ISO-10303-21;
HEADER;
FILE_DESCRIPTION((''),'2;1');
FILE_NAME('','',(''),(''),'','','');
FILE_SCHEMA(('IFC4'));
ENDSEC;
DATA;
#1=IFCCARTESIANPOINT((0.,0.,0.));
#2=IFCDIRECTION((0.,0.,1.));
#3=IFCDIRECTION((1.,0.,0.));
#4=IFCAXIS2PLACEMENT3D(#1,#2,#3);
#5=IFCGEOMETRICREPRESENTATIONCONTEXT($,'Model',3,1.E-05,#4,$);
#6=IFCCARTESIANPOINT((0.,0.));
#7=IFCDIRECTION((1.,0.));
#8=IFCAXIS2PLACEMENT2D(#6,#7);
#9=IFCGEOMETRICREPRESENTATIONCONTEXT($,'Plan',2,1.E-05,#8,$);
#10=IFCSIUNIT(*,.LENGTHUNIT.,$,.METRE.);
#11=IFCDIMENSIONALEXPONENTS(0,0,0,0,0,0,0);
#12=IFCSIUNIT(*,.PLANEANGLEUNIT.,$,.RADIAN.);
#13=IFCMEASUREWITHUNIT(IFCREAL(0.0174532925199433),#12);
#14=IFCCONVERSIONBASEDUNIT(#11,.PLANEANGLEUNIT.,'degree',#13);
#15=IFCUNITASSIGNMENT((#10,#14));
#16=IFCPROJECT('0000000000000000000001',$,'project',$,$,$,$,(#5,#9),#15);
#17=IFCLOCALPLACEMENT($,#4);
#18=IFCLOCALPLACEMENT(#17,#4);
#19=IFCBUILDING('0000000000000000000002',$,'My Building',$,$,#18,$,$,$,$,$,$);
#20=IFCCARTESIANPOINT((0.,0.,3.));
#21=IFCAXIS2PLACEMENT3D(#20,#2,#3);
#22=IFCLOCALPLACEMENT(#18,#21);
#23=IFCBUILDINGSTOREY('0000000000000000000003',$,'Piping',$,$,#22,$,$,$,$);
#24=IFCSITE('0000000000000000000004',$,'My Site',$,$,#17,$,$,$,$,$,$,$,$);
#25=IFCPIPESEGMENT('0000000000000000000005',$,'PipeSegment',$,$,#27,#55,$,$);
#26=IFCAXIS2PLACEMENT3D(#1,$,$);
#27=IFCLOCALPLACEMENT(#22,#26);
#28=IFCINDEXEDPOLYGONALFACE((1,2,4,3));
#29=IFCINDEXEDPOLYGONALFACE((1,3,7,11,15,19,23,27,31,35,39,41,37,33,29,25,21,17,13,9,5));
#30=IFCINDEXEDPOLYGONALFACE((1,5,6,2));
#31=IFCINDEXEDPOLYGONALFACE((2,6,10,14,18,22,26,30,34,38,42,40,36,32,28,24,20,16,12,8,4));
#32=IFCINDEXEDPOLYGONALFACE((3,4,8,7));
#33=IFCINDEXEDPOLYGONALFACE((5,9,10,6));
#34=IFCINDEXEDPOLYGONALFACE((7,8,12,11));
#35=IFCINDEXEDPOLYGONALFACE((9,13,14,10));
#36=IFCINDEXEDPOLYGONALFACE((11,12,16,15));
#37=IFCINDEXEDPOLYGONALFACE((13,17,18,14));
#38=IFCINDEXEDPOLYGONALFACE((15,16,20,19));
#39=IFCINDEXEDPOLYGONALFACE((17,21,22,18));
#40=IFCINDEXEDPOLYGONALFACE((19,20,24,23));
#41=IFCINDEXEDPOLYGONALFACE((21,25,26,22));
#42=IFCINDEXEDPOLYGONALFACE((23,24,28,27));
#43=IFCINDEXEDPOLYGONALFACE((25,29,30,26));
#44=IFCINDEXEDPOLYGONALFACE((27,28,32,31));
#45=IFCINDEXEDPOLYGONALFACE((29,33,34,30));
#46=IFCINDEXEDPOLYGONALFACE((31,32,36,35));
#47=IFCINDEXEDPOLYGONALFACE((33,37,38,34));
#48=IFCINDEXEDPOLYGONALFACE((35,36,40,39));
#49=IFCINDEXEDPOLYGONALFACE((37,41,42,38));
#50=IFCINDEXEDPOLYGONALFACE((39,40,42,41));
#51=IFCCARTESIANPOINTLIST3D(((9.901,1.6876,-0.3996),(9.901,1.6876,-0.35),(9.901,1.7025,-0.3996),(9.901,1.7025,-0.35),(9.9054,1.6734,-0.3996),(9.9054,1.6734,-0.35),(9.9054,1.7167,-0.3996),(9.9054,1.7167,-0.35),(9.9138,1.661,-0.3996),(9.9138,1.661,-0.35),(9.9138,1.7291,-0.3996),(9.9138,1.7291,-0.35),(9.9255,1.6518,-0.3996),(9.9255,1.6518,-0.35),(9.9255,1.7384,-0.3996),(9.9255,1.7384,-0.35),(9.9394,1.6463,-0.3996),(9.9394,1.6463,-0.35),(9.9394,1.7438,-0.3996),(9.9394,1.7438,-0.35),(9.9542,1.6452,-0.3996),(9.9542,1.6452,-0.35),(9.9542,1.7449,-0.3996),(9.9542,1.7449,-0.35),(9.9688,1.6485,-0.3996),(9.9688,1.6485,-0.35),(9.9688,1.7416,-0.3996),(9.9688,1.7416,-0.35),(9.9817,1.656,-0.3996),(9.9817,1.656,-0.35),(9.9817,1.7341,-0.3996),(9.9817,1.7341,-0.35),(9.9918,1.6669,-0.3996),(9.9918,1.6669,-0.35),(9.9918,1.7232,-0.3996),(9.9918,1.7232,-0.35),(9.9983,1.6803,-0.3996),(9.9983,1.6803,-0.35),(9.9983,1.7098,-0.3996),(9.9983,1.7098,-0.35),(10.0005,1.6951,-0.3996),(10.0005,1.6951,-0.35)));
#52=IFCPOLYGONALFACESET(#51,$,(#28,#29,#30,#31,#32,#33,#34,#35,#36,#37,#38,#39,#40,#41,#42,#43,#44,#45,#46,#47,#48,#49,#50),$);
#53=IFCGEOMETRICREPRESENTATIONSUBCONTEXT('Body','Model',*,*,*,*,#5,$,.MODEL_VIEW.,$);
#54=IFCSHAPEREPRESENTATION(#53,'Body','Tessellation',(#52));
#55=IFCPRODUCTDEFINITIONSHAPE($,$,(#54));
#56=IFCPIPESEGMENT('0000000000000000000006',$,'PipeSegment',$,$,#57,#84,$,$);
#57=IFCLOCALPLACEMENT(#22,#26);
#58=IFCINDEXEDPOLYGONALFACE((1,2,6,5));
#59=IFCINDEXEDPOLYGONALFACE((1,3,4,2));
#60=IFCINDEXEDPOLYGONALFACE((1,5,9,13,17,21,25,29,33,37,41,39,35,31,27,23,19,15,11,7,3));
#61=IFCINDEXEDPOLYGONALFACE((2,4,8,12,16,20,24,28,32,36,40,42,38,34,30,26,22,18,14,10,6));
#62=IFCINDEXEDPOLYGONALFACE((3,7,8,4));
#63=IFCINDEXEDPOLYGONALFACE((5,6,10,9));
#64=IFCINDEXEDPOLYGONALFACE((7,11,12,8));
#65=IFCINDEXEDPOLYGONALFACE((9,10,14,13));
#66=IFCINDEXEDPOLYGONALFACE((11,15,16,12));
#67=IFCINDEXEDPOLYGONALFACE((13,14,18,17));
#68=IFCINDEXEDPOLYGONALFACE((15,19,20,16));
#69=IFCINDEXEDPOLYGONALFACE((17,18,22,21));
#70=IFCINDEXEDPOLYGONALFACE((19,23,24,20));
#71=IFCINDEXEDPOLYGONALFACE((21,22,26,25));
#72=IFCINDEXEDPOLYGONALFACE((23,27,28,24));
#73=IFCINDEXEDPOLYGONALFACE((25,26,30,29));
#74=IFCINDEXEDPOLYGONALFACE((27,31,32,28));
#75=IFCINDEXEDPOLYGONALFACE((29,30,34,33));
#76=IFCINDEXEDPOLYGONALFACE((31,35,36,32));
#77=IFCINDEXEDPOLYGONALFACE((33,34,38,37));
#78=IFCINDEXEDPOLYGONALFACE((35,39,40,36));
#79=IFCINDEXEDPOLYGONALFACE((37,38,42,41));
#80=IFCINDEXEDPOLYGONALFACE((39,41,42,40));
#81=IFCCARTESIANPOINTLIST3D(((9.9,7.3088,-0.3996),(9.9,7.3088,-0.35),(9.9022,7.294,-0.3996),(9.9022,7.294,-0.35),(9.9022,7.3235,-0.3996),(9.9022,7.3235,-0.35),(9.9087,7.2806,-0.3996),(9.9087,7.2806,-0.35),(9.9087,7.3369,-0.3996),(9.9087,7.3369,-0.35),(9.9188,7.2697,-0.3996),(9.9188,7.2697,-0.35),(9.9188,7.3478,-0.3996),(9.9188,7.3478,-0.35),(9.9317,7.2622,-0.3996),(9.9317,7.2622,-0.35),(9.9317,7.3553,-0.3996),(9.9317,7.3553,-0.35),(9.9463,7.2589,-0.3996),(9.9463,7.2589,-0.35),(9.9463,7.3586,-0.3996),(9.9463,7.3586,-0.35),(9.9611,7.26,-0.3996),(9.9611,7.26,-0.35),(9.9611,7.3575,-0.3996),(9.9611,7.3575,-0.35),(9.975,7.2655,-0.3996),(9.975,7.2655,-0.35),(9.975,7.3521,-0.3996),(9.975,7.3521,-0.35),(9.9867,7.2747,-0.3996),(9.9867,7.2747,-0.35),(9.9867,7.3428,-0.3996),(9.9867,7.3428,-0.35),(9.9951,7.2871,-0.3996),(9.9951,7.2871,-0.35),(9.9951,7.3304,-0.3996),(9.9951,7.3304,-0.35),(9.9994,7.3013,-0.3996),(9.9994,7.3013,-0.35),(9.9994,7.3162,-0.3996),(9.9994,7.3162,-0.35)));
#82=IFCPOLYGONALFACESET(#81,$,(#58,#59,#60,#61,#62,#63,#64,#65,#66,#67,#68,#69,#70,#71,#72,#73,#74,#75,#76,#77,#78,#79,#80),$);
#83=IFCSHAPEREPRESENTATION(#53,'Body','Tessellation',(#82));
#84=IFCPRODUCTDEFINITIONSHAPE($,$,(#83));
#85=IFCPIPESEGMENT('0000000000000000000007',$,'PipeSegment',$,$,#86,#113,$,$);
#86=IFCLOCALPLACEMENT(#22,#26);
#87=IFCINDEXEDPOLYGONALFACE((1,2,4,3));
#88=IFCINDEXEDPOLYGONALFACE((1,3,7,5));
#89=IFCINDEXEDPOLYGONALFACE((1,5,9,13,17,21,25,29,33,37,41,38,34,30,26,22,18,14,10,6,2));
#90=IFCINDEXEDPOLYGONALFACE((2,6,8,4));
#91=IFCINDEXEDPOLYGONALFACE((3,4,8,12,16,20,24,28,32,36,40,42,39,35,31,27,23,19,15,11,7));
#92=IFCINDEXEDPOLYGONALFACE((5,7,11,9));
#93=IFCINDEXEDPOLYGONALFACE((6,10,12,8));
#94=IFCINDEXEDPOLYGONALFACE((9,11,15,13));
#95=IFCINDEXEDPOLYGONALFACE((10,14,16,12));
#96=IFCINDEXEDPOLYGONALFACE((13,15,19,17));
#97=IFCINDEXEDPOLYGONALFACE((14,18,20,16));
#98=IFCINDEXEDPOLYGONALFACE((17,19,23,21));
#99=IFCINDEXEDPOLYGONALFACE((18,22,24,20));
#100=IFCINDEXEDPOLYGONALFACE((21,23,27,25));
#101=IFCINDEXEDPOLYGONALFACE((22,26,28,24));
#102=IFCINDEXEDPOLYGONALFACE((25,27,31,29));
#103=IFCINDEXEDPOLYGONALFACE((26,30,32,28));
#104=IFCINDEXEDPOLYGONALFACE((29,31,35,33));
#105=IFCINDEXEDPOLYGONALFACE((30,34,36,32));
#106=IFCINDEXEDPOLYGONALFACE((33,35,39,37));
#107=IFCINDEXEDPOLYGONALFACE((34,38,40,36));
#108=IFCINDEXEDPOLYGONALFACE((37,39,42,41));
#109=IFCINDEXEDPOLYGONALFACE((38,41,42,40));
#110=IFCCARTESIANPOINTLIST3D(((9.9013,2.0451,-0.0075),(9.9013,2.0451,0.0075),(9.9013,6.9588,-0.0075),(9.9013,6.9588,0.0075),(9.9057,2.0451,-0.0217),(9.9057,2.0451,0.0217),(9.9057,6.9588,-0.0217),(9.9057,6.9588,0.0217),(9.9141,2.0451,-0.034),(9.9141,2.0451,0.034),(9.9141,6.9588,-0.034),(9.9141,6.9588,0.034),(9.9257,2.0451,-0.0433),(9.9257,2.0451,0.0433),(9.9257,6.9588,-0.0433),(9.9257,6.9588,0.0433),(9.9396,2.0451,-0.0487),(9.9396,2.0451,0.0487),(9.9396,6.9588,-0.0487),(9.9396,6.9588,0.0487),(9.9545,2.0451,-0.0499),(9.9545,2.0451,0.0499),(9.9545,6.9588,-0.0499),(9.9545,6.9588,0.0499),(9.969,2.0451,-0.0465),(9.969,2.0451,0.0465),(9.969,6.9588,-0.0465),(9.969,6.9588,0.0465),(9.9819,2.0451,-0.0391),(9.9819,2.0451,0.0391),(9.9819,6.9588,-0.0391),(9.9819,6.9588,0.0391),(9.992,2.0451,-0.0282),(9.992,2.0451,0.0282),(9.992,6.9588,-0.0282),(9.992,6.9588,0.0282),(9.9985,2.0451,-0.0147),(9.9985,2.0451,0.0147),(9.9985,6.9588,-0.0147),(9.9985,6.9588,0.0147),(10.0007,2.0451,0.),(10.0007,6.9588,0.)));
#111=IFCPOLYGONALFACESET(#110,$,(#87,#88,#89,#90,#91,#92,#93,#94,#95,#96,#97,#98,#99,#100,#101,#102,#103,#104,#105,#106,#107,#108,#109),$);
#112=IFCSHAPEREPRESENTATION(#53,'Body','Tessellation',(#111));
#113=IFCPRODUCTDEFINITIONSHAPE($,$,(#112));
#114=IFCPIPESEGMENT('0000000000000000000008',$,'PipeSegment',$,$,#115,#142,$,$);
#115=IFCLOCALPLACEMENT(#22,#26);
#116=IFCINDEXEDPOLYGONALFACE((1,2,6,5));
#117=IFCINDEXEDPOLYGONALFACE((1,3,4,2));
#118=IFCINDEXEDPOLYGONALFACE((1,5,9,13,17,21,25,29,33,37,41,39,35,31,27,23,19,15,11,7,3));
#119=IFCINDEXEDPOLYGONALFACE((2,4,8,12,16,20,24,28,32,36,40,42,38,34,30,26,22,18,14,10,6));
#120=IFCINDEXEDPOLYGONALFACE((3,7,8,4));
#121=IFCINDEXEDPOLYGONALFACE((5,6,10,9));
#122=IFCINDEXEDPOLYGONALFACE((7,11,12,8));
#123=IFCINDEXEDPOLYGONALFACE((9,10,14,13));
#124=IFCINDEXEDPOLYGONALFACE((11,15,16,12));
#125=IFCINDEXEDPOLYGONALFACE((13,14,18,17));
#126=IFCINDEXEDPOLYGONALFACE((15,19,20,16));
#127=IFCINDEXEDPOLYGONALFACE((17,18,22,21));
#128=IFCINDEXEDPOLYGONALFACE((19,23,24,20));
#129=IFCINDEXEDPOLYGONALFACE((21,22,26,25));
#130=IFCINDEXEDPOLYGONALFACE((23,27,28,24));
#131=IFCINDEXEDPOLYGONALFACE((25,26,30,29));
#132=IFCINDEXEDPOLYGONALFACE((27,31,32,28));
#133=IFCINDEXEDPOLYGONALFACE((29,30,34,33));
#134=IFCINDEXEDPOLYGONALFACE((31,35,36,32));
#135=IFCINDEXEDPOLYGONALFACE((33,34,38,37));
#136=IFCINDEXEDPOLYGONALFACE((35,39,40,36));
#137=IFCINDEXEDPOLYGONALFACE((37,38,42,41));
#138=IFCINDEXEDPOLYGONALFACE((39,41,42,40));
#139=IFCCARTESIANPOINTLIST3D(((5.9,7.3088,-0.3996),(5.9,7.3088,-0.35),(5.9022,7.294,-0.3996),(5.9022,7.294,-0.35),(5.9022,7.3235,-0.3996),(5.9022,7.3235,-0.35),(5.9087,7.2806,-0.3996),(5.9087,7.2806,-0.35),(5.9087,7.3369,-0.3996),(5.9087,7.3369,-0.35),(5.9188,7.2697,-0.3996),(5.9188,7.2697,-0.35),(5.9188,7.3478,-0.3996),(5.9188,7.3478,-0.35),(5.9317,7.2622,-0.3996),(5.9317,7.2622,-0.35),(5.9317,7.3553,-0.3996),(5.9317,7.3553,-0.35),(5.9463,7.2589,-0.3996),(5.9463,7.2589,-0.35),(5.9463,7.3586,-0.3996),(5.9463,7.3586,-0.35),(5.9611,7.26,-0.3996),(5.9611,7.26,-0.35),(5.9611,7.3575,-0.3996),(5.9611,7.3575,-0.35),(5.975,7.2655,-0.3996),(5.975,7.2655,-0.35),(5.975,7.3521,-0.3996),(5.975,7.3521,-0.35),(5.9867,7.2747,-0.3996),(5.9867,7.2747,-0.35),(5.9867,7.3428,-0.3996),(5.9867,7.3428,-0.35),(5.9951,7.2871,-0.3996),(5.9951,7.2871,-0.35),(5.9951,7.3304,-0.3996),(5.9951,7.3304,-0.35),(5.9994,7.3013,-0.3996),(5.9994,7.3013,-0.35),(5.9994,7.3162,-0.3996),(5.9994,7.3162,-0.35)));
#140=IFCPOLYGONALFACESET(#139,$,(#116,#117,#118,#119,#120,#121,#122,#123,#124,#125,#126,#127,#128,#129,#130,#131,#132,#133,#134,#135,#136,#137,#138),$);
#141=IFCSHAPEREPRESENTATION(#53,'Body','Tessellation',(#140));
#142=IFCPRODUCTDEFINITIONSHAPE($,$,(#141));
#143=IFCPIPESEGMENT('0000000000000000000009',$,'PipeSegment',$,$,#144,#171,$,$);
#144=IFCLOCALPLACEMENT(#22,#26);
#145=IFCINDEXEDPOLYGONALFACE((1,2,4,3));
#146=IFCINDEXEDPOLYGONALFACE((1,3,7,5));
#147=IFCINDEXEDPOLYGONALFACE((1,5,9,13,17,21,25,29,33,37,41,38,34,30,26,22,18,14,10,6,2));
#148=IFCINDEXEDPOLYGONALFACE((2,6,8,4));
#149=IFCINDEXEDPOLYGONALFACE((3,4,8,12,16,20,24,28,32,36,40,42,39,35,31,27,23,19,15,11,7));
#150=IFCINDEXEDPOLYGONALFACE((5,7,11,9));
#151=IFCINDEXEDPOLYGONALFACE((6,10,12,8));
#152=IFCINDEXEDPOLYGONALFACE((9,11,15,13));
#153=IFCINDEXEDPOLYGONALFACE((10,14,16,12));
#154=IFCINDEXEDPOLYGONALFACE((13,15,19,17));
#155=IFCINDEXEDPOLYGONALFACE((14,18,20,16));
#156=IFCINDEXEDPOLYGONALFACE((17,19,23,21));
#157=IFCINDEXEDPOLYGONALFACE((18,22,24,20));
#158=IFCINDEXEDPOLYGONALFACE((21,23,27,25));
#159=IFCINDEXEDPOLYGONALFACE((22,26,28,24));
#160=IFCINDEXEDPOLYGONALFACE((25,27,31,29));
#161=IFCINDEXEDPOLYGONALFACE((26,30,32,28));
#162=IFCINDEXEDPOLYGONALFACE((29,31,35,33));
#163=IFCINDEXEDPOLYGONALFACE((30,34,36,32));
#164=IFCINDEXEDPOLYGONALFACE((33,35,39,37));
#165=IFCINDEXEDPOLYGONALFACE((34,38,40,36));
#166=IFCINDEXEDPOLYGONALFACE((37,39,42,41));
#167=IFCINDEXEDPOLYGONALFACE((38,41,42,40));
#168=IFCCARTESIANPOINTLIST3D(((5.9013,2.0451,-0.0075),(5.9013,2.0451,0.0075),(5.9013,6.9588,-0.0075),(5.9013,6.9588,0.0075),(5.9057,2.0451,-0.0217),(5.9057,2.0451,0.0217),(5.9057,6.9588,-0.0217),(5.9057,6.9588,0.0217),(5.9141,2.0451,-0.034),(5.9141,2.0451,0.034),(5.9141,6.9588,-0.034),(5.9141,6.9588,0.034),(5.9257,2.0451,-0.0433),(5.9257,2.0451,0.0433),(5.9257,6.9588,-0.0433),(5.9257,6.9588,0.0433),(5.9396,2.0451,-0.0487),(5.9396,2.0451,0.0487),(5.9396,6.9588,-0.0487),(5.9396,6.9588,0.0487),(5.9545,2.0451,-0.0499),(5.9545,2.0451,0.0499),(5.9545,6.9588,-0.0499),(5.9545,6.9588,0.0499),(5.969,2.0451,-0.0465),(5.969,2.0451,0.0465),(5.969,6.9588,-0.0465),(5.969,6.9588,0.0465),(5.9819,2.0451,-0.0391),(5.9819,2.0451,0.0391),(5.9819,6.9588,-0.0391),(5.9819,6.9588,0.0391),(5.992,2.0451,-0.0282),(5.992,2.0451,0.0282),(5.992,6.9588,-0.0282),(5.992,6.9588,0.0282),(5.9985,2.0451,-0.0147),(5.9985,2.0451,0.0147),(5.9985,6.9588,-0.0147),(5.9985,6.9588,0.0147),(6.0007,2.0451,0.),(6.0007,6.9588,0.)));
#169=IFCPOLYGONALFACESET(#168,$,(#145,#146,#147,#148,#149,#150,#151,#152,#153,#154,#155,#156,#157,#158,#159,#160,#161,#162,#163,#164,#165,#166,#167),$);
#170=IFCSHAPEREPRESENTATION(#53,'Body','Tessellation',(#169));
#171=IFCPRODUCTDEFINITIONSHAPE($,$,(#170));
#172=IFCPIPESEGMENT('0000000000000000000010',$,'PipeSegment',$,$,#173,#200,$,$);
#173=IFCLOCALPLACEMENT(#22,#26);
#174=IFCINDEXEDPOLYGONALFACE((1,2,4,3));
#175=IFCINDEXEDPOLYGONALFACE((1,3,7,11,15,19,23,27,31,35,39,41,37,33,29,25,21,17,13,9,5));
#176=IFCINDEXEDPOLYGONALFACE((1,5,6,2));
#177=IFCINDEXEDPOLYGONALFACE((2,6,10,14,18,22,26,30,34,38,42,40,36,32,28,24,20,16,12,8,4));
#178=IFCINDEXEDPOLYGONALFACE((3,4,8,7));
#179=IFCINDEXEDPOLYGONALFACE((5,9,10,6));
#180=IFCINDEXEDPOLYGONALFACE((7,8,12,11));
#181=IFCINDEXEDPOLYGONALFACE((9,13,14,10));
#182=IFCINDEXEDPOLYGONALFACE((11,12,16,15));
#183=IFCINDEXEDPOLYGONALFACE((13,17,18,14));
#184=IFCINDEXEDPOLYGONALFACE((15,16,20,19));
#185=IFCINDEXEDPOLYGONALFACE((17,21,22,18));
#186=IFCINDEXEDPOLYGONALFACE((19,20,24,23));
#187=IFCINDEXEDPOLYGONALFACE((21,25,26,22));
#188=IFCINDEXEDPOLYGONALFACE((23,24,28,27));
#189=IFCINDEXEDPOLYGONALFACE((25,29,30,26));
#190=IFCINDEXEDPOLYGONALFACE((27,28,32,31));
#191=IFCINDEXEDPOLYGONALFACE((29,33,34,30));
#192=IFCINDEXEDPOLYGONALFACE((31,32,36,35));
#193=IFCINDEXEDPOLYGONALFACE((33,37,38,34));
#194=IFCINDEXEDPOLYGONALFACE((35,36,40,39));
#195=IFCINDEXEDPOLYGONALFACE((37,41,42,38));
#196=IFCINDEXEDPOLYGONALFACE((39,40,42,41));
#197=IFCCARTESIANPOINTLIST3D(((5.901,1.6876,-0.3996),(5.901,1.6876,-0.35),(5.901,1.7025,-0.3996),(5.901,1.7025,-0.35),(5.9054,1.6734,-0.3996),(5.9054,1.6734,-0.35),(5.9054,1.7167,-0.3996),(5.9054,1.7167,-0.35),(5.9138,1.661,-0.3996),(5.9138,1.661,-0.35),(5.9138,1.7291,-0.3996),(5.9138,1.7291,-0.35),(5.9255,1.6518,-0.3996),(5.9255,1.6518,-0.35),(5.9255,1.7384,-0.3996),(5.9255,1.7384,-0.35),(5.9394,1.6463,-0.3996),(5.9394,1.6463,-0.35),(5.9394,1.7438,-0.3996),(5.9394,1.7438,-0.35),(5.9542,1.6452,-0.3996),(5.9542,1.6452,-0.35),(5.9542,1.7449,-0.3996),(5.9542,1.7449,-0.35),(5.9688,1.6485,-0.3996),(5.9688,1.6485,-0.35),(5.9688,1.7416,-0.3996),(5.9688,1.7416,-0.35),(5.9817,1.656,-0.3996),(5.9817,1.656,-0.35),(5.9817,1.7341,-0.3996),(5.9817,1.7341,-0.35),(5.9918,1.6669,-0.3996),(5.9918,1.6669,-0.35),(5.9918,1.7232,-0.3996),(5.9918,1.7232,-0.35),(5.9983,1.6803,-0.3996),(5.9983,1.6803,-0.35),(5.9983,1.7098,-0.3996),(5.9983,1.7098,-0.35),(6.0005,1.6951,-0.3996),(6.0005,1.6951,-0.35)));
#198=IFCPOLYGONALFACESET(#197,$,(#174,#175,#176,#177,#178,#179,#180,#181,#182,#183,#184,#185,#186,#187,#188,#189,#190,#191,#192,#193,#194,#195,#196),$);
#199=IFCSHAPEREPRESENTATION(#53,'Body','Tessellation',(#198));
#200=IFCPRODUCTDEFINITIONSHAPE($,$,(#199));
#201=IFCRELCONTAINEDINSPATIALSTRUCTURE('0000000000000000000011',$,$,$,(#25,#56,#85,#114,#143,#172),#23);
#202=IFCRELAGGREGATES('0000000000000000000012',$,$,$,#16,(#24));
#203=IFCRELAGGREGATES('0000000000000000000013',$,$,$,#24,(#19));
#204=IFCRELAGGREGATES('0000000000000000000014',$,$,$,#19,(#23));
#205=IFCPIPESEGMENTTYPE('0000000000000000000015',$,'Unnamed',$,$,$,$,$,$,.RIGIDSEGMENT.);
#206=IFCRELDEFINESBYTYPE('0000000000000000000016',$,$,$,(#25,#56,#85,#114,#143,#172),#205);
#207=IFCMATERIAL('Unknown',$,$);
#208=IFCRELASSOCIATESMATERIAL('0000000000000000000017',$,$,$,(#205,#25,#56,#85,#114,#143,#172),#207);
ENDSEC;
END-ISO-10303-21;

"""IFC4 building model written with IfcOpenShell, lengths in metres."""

from ifc_helpers import new_model, entity, si_unit, converted_unit, frame, origin_with_axes, origin_2d_with_axis, place, context, subcontext, project, spatial, circle, extrude, material, material_profile, profile_set, profile_usage, type_object, element, save


model = new_model("IFC4")

# Units and contexts
model_context = context("Model", 3, precision=1e-05, world=origin_with_axes())
plan_context = context("Plan", 2, precision=1e-05, world=origin_2d_with_axis())
body_context = subcontext(model_context, "Body", "Model", "MODEL_VIEW")
ifc_project = project(units=[si_unit("LENGTHUNIT", "METRE"), converted_unit("PLANEANGLEUNIT", "degree", entity("IfcReal", 0.0174532925199433), si_unit("PLANEANGLEUNIT", "RADIAN"), dimensions=[0, 0, 0, 0, 0, 0, 0])], contexts=[model_context, plan_context])

# Site, building, storey
site_placement = place(None, origin_with_axes())
site = spatial("IfcSite", under=ifc_project, at=site_placement, Name="My Site")
building_placement = place(site_placement, origin_with_axes())
building = spatial("IfcBuilding", under=site, at=building_placement, Name="My Building")
storey_placement = place(building_placement, frame((0.0, 0.0, 3.0), z_axis=(0.0, 0.0, 1.0), x_axis=(1.0, 0.0, 0.0)))
storey = spatial("IfcBuildingStorey", under=building, at=storey_placement, Name="Piping")

# Pipe segments
ifc_material = material(Name="Unknown")
ifc_material_profile = material_profile(ifc_material, circle(Radius=0.05))
ifc_profile_set = profile_set([ifc_material_profile])
ifc_profile_usage_1 = profile_usage(ifc_profile_set, cardinal=5)
pipe_segment_type = type_object("IfcPipeSegmentType", Name="Unnamed", PredefinedType="RIGIDSEGMENT", material=ifc_profile_set)
pipe_segment_1_placement = place(storey_placement, frame((9.9505, 1.6951, -0.35), z_axis=(0.0, 0.0, -1.0), x_axis=(1.0, 0.0, 0.0)))
element("IfcPipeSegment", 1, at=pipe_segment_1_placement, inside=storey, type_object=pipe_segment_type, material=ifc_profile_usage_1, Name="PipeSegment", context=body_context, shape_type="SweptSolid", body=[
    extrude(circle(Radius=0.05), origin_with_axes(), (0.0, 0.0, 1.0), 0.0496),
])
ifc_profile_usage_2 = profile_usage(ifc_profile_set, cardinal=5)
pipe_segment_2_placement = place(storey_placement, frame((9.95, 7.3088, -0.35), z_axis=(0.0, 0.0, -1.0), x_axis=(-1.0, 0.0, 0.0)))
element("IfcPipeSegment", 2, at=pipe_segment_2_placement, inside=storey, type_object=pipe_segment_type, material=ifc_profile_usage_2, Name="PipeSegment", context=body_context, shape_type="SweptSolid", body=[
    extrude(circle(Radius=0.05), origin_with_axes(), (0.0, 0.0, 1.0), 0.0496),
])
ifc_profile_usage_3 = profile_usage(ifc_profile_set, cardinal=5)
pipe_segment_3_placement = place(storey_placement, frame((9.9507, 6.9588, 0.0), z_axis=(0.0, -1.0, 0.0), x_axis=(1.0, 0.0, 0.0)))
element("IfcPipeSegment", 3, at=pipe_segment_3_placement, inside=storey, type_object=pipe_segment_type, material=ifc_profile_usage_3, Name="PipeSegment", context=body_context, shape_type="SweptSolid", body=[
    extrude(circle(Radius=0.05), origin_with_axes(), (0.0, 0.0, 1.0), 4.9137),
])
ifc_profile_usage_4 = profile_usage(ifc_profile_set, cardinal=5)
pipe_segment_4_placement = place(storey_placement, frame((5.95, 7.3088, -0.35), z_axis=(0.0, 0.0, -1.0), x_axis=(-1.0, 0.0, 0.0)))
element("IfcPipeSegment", 4, at=pipe_segment_4_placement, inside=storey, type_object=pipe_segment_type, material=ifc_profile_usage_4, Name="PipeSegment", context=body_context, shape_type="SweptSolid", body=[
    extrude(circle(Radius=0.05), origin_with_axes(), (0.0, 0.0, 1.0), 0.0496),
])
ifc_profile_usage_5 = profile_usage(ifc_profile_set, cardinal=5)
pipe_segment_5_placement = place(storey_placement, frame((5.9507, 6.9588, 0.0), z_axis=(0.0, -1.0, 0.0), x_axis=(1.0, 0.0, 0.0)))
element("IfcPipeSegment", 5, at=pipe_segment_5_placement, inside=storey, type_object=pipe_segment_type, material=ifc_profile_usage_5, Name="PipeSegment", context=body_context, shape_type="SweptSolid", body=[
    extrude(circle(Radius=0.05), origin_with_axes(), (0.0, 0.0, 1.0), 4.9137),
])
ifc_profile_usage_6 = profile_usage(ifc_profile_set, cardinal=5)
pipe_segment_6_placement = place(storey_placement, frame((5.9505, 1.6951, -0.35), z_axis=(0.0, 0.0, -1.0), x_axis=(1.0, 0.0, 0.0)))
element("IfcPipeSegment", 6, at=pipe_segment_6_placement, inside=storey, type_object=pipe_segment_type, material=ifc_profile_usage_6, Name="PipeSegment", context=body_context, shape_type="SweptSolid", body=[
    extrude(circle(Radius=0.05), origin_with_axes(), (0.0, 0.0, 1.0), 0.0496),
])

save(model, "model.ifc")
